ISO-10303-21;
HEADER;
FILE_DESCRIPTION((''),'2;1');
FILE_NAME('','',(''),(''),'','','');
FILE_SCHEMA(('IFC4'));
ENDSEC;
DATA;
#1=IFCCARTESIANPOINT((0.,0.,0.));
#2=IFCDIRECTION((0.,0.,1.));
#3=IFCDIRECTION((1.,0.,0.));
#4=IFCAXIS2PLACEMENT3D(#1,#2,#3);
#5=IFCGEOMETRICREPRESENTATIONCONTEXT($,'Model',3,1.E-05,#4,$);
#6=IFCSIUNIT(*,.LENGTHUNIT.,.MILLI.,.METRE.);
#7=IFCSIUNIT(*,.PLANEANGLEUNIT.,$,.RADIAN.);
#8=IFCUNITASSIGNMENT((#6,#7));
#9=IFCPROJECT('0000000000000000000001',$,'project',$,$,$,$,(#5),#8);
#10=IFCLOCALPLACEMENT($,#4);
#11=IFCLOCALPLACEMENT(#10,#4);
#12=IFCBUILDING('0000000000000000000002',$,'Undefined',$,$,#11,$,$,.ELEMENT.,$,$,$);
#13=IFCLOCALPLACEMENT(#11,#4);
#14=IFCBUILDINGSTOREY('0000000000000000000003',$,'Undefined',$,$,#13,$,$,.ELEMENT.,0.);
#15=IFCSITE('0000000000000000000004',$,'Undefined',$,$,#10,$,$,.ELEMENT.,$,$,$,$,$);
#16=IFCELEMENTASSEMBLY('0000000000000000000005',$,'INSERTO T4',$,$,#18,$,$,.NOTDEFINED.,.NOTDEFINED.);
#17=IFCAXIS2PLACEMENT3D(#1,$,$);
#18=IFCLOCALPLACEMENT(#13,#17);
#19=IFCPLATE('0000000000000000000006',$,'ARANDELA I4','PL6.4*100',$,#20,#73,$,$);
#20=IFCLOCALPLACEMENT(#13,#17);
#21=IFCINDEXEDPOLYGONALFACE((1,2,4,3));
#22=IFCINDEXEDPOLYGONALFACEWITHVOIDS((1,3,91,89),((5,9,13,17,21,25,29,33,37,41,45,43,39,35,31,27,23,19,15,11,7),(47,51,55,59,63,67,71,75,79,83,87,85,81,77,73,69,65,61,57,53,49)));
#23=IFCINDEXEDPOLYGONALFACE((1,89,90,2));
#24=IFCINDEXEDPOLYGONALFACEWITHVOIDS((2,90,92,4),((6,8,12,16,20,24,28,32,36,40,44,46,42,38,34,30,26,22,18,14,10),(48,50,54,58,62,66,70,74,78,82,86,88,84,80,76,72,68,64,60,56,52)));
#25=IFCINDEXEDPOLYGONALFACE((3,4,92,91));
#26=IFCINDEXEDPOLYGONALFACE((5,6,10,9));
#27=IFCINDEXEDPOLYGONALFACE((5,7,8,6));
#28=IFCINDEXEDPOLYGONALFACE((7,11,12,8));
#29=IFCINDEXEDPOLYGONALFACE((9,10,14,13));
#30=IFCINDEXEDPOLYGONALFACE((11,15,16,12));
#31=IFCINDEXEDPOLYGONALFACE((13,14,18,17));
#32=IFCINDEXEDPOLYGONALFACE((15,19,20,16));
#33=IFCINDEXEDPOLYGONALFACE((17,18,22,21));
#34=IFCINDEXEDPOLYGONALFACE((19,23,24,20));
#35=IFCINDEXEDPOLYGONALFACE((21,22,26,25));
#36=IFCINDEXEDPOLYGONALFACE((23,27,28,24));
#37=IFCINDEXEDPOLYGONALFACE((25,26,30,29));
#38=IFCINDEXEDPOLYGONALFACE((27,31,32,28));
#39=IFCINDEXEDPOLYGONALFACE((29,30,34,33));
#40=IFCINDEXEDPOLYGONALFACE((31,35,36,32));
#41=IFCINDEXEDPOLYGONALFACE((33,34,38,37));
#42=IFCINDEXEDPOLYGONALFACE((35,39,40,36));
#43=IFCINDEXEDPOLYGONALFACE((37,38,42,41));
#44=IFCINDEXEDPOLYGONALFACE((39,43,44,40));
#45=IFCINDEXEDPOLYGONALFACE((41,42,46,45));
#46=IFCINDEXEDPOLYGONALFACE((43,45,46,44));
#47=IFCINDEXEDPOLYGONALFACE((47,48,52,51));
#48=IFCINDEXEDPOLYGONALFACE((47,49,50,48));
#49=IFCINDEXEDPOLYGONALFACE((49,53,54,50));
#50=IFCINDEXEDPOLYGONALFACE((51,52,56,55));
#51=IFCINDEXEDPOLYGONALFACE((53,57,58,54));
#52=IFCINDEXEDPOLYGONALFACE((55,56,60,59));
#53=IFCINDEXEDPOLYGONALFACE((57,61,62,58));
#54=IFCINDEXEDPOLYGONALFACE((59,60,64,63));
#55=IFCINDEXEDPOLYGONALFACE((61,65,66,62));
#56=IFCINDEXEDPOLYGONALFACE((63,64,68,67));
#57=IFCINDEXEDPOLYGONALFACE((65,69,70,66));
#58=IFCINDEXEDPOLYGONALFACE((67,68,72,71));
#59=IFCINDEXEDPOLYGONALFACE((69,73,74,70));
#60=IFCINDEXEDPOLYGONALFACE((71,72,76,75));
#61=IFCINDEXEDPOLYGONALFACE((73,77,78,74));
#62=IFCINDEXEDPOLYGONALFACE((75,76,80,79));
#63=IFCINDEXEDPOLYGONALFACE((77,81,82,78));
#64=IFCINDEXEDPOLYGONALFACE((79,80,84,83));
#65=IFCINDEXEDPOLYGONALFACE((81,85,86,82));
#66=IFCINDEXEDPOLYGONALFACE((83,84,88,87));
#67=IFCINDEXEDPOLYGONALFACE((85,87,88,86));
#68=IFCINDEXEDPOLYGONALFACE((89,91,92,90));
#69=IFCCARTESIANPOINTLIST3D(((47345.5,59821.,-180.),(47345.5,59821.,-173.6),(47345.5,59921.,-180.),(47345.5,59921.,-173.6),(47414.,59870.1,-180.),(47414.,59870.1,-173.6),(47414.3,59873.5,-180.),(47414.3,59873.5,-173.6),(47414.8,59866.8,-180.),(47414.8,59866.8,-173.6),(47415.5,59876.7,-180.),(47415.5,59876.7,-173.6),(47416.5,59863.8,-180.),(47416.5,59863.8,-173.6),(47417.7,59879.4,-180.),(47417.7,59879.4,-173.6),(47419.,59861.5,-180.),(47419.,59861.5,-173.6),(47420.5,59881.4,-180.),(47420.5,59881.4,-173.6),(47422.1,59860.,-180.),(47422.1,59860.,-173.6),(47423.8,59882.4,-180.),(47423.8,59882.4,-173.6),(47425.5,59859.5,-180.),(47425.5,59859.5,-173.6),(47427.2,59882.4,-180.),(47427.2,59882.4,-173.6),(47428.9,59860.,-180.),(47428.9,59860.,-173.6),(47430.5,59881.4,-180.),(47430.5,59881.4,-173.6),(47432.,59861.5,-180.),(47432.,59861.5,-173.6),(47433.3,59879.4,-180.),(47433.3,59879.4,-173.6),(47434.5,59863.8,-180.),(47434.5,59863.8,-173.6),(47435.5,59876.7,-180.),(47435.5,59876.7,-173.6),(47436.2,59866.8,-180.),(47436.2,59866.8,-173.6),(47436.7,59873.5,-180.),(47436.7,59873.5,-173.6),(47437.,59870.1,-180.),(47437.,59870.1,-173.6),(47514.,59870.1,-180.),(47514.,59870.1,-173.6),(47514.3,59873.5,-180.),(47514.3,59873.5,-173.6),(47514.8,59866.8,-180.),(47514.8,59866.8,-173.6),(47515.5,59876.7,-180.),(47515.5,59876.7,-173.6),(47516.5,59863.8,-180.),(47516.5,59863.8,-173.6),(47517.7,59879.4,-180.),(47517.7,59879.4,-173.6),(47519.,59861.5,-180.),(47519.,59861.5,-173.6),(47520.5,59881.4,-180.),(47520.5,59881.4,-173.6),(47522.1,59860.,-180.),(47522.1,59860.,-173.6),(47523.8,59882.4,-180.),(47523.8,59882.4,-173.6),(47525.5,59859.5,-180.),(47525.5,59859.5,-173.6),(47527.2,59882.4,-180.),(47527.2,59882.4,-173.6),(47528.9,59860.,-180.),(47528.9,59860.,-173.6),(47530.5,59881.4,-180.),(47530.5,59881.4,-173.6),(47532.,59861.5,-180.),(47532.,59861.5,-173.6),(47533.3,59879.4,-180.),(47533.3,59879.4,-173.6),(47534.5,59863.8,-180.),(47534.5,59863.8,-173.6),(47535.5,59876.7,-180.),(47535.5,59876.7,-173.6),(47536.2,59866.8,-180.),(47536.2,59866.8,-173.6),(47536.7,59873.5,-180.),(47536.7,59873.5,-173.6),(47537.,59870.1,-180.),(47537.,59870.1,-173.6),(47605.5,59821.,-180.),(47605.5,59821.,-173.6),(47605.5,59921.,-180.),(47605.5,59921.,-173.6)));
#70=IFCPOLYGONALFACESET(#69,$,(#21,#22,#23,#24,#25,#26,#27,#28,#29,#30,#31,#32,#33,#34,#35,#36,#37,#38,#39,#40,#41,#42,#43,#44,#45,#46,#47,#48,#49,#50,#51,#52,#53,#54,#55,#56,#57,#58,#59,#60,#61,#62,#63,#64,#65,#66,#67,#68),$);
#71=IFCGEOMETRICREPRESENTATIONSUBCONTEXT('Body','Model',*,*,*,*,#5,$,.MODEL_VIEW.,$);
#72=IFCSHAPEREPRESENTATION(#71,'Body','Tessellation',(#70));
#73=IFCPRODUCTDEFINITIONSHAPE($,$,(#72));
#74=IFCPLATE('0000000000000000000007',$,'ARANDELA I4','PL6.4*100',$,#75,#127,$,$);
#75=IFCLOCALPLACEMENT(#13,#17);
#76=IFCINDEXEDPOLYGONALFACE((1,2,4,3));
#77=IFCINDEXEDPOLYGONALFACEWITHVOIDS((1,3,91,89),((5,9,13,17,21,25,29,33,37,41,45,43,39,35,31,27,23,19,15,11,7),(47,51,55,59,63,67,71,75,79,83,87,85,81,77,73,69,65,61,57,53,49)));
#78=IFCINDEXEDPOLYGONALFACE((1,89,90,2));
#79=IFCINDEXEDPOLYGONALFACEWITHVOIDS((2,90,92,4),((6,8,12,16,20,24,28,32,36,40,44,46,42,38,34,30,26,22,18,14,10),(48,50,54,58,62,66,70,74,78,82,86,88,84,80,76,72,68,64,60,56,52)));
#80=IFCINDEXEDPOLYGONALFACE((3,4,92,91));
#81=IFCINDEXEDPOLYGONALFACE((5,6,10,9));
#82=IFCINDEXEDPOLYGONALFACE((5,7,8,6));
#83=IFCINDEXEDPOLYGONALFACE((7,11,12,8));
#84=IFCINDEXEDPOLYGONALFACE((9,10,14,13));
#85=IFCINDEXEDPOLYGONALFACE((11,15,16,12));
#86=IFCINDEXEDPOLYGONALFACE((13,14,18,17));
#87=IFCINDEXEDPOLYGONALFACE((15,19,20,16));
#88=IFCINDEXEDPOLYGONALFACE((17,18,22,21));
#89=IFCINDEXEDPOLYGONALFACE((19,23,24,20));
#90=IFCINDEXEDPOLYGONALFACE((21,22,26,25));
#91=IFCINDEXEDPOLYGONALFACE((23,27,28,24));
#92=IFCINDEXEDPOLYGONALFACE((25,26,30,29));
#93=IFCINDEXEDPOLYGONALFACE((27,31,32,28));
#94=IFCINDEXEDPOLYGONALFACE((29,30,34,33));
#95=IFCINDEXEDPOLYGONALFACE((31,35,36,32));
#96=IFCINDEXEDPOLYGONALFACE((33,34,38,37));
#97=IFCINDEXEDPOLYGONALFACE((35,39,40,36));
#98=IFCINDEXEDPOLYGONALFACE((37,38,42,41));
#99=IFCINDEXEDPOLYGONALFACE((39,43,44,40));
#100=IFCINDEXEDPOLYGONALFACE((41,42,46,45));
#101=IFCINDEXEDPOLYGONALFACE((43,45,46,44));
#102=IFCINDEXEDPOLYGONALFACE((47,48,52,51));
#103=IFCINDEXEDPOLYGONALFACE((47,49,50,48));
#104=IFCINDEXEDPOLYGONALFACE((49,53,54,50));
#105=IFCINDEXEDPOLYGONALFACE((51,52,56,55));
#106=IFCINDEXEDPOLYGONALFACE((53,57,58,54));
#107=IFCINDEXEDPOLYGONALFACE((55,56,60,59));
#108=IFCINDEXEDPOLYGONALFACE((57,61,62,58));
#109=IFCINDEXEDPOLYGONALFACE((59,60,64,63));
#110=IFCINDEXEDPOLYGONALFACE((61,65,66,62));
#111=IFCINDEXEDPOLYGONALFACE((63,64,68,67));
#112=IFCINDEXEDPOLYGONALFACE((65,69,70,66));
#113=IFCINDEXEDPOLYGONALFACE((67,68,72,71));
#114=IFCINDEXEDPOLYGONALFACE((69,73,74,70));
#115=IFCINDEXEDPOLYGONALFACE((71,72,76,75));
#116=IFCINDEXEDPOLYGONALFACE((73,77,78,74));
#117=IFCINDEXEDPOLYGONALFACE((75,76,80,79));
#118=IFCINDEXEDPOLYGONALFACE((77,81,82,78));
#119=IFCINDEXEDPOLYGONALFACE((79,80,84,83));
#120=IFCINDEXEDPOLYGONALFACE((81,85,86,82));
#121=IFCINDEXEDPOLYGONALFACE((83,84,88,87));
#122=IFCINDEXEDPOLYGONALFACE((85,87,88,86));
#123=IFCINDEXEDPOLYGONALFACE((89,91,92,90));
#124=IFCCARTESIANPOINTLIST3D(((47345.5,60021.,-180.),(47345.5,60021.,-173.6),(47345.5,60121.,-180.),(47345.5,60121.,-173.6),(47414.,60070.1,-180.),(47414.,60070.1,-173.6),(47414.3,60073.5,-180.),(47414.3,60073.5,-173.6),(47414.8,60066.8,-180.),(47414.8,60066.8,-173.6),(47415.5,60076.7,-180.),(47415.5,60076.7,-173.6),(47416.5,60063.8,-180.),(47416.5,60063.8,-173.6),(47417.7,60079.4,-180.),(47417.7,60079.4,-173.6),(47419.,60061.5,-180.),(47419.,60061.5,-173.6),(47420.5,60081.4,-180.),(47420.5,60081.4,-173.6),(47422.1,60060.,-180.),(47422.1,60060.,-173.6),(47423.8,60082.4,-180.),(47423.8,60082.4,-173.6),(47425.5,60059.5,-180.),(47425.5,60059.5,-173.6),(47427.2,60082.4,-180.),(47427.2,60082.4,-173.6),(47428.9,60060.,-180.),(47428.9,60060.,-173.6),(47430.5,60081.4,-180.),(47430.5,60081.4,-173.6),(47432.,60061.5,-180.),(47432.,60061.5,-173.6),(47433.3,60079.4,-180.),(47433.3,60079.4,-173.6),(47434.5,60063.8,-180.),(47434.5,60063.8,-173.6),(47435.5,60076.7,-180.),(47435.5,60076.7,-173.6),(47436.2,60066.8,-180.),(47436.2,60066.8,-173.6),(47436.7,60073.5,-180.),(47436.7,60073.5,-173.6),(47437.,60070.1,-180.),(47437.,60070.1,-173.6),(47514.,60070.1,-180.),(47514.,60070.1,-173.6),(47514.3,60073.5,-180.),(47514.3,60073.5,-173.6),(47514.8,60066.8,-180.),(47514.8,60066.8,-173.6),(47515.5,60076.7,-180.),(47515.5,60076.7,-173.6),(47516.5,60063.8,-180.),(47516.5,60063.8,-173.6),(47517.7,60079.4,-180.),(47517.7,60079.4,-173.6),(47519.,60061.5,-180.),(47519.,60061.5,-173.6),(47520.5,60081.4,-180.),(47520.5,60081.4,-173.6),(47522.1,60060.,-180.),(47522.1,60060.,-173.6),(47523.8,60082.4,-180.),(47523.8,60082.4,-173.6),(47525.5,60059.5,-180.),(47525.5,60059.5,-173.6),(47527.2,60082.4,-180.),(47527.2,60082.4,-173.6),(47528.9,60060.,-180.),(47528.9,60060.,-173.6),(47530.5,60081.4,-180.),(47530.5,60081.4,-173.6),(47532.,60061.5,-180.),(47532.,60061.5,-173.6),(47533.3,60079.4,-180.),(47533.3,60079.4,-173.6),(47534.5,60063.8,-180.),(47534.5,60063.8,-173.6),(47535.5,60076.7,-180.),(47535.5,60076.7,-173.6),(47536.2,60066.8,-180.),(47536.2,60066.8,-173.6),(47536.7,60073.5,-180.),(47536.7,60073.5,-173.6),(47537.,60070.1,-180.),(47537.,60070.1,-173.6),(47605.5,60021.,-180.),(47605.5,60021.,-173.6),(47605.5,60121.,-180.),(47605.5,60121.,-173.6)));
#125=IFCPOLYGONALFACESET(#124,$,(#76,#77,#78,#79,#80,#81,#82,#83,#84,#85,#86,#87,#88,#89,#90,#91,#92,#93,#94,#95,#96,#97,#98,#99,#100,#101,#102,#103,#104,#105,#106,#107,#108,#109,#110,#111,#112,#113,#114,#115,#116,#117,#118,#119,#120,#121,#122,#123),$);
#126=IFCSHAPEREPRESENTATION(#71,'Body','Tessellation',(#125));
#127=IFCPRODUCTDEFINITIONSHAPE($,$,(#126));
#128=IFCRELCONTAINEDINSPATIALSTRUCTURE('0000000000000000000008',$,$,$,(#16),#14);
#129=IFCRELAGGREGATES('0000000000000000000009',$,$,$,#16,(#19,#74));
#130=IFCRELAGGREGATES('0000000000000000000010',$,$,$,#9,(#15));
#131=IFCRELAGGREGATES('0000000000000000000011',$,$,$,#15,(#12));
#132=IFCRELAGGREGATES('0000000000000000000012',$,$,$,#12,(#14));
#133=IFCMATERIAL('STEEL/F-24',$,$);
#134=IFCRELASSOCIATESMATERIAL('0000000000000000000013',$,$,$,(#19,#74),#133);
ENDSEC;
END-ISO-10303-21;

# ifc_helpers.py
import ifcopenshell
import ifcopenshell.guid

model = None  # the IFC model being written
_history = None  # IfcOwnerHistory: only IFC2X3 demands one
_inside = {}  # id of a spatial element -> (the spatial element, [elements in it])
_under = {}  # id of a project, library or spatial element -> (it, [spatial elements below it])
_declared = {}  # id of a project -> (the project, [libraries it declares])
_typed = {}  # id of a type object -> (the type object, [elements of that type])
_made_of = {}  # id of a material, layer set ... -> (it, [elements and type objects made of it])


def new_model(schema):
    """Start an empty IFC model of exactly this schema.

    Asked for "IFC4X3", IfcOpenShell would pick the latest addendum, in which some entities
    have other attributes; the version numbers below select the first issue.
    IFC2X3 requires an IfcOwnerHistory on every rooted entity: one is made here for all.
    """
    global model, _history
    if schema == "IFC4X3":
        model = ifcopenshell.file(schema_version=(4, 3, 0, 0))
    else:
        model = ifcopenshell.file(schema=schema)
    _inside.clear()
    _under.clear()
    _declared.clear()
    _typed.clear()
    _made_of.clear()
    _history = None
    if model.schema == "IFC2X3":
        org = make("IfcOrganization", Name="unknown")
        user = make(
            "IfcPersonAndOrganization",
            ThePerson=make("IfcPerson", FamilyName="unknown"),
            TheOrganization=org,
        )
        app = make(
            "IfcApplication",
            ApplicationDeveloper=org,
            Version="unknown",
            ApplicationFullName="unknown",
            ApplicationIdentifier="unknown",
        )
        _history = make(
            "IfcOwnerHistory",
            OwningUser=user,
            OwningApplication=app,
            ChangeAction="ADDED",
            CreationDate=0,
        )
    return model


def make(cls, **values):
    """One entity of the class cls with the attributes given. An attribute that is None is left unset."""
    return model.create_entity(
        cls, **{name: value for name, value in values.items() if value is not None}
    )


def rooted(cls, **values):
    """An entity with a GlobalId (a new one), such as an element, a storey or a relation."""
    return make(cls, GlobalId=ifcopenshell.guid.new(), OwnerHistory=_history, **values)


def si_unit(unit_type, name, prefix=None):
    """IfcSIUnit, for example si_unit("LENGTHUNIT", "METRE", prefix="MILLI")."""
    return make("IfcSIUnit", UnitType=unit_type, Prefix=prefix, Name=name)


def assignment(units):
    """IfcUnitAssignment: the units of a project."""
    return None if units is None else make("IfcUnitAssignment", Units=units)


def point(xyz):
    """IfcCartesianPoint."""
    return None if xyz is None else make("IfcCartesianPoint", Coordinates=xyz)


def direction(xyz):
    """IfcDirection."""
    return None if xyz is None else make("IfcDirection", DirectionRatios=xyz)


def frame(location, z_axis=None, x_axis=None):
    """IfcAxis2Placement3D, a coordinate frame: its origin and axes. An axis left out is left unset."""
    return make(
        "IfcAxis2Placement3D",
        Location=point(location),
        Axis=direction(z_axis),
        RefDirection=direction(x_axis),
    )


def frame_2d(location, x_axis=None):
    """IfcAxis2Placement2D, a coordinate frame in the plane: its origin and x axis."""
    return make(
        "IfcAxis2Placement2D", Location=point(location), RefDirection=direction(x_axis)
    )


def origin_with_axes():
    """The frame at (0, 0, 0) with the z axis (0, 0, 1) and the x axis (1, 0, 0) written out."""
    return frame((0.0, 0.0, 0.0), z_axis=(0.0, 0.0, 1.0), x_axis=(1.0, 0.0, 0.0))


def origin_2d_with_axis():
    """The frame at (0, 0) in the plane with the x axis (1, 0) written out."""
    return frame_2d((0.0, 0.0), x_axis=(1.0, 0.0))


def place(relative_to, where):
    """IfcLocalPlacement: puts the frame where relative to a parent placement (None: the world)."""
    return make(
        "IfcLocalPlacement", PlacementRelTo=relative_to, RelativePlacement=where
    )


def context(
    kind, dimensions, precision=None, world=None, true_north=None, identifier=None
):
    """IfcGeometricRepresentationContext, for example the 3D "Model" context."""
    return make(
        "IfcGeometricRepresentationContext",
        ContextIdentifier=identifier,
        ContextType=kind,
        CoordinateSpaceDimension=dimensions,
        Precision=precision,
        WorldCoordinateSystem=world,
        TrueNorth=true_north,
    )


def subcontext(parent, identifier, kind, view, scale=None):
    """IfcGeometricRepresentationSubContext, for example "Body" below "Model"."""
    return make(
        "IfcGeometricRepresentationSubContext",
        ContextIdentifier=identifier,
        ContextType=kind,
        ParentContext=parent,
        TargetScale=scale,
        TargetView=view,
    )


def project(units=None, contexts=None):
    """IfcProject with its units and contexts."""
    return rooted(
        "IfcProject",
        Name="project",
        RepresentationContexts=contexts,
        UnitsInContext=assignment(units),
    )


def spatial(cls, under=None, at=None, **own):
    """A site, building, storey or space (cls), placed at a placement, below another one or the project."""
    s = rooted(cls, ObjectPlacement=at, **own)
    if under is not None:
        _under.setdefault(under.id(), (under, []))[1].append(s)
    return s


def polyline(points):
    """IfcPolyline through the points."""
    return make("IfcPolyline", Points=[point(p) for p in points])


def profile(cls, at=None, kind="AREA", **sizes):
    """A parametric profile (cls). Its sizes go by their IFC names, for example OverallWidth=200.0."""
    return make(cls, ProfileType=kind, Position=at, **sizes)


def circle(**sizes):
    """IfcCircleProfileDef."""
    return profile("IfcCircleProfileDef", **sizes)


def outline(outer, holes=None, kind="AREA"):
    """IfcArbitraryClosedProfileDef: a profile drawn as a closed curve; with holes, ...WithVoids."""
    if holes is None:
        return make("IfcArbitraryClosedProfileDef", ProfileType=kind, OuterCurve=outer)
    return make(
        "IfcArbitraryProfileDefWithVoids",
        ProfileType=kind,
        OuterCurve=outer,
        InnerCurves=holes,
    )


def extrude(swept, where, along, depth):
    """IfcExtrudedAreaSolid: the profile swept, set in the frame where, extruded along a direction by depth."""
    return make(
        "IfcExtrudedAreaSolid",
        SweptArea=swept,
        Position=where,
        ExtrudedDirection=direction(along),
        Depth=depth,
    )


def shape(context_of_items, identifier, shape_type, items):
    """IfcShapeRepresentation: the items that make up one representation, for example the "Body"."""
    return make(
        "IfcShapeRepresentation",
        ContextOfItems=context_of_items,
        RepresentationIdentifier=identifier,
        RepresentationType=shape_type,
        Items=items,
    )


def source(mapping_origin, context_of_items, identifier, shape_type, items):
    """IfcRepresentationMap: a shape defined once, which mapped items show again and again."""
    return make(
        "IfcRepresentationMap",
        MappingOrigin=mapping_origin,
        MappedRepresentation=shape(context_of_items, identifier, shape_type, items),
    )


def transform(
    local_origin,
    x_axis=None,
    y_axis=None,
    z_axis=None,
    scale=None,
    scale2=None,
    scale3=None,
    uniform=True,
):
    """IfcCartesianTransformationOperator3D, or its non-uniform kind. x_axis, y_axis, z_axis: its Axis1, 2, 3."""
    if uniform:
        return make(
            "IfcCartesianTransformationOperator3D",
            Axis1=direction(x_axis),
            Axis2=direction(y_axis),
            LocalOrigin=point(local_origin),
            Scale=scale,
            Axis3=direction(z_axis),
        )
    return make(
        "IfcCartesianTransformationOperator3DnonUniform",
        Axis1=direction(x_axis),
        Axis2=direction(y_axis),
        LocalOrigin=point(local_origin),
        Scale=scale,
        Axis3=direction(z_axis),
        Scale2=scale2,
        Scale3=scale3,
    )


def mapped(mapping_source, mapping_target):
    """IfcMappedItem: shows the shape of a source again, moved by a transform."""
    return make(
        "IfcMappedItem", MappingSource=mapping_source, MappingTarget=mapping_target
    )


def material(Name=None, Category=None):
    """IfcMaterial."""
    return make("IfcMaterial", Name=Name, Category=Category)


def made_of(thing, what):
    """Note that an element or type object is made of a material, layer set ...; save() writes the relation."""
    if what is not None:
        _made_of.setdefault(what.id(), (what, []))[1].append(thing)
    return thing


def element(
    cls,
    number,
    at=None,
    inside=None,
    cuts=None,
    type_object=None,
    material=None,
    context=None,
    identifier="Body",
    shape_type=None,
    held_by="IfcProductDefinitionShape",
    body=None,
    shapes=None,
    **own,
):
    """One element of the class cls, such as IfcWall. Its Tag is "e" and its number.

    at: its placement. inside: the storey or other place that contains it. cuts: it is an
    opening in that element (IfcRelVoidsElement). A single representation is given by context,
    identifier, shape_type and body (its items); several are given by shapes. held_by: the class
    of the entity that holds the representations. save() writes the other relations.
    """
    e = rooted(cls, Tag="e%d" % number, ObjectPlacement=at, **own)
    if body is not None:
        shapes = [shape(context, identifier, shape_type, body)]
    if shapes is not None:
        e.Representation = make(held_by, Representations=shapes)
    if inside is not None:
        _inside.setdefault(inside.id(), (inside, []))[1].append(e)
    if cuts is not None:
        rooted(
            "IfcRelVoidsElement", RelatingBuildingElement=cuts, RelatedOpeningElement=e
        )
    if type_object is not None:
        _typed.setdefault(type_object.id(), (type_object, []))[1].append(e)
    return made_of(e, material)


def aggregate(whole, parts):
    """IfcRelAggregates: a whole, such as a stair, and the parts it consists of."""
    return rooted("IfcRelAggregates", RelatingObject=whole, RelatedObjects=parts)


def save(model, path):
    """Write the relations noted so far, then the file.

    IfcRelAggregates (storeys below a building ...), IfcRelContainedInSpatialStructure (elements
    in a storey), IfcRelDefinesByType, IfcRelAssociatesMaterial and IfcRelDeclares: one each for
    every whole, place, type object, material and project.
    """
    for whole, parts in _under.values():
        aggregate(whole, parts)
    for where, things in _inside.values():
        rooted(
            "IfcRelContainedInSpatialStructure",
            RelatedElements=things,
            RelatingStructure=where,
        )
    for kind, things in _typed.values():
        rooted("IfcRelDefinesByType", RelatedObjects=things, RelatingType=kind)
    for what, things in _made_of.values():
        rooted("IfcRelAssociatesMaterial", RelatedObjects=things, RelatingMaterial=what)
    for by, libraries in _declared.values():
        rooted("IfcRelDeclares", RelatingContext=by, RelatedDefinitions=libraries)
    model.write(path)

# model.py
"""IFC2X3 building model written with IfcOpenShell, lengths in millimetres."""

from ifc_helpers import new_model, si_unit, frame, origin_with_axes, origin_2d_with_axis, place, context, subcontext, project, spatial, polyline, circle, outline, extrude, source, transform, mapped, material, element, aggregate, save


model = new_model("IFC2X3")

# Units and contexts
model_context = context("Model", 3, precision=1e-05, world=origin_with_axes())
body_context = subcontext(model_context, "Body", "Model", "MODEL_VIEW")
ifc_project = project(units=[si_unit("LENGTHUNIT", "METRE", prefix="MILLI"), si_unit("PLANEANGLEUNIT", "RADIAN")], contexts=[model_context])

# Site, building, storey
site_placement = place(None, origin_with_axes())
site = spatial("IfcSite", under=ifc_project, at=site_placement, Name="Undefined", CompositionType="ELEMENT")
building_placement = place(site_placement, origin_with_axes())
building = spatial("IfcBuilding", under=site, at=building_placement, Name="Undefined", CompositionType="ELEMENT")
storey_placement = place(building_placement, origin_with_axes())
storey = spatial("IfcBuildingStorey", under=building, at=storey_placement, Name="Undefined", CompositionType="ELEMENT", Elevation=0.0)

# Element assembly
assembly_1_placement = place(storey_placement, origin_with_axes())
assembly_1 = element("IfcElementAssembly", 1, at=assembly_1_placement, inside=storey, Name="INSERTO T4", AssemblyPlace="NOTDEFINED", PredefinedType="NOTDEFINED")

# Plates, openings
ifc_material_1 = material(Name="STEEL/F-24")
plate_1_placement = place(assembly_1_placement, frame((47345.5, 59821.0, -176.8), z_axis=(0.0, 0.0, -1.0), x_axis=(0.0, 1.0, 0.0)))
plate_1 = element("IfcPlate", 2, at=plate_1_placement, material=ifc_material_1, Name="ARANDELA I4", Description="PL6.4*100", context=body_context, shape_type="SweptSolid", body=[
    extrude(outline(polyline([(0.0, 0.0), (100.0, 0.0), (100.0, 260.0), (0.0, 260.0), (0.0, 0.0)])), frame((0.0, 0.0, -3.2), z_axis=(0.0, 0.0, 1.0), x_axis=(1.0, 0.0, 0.0)), (0.0, 0.0, 1.0), 6.4),
])
shared_shape_1 = source(origin_with_axes(), body_context, "Body", "SweptSolid", [
    extrude(circle(Radius=11.5, at=origin_2d_with_axis()), frame((0.0, -0.1, 0.0), z_axis=(0.0, 1.0, 0.0), x_axis=(1.0, 0.0, 0.0)), (0.0, 0.0, 1.0), 6.6),
])
opening_1_placement = place(assembly_1_placement, frame((47475.5, 59871.0, -173.6), z_axis=(1.0, 0.0, 0.0), x_axis=(0.0, -1.0, 0.0)))
element("IfcOpeningElement", 3, at=opening_1_placement, cuts=plate_1, ObjectType="Opening", context=body_context, shape_type="MappedRepresentation", body=[
    mapped(shared_shape_1, transform((0.0, 0.0, 50.0))),
    mapped(shared_shape_1, transform((0.0, 0.0, -50.0))),
])
plate_2_placement = place(assembly_1_placement, frame((47345.5, 60021.0, -176.8), z_axis=(0.0, 0.0, -1.0), x_axis=(0.0, 1.0, 0.0)))
plate_2 = element("IfcPlate", 4, at=plate_2_placement, material=ifc_material_1, Name="ARANDELA I4", Description="PL6.4*100", context=body_context, shape_type="SweptSolid", body=[
    extrude(outline(polyline([(0.0, 0.0), (100.0, 0.0), (100.0, 260.0), (0.0, 260.0), (0.0, 0.0)])), frame((0.0, 0.0, -3.2), z_axis=(0.0, 0.0, 1.0), x_axis=(1.0, 0.0, 0.0)), (0.0, 0.0, 1.0), 6.4),
])
opening_2_placement = place(assembly_1_placement, frame((47475.5, 60071.0, -173.6), z_axis=(1.0, 0.0, 0.0), x_axis=(0.0, -1.0, 0.0)))
element("IfcOpeningElement", 5, at=opening_2_placement, cuts=plate_2, ObjectType="Opening", context=body_context, shape_type="MappedRepresentation", body=[
    mapped(shared_shape_1, transform((0.0, 0.0, 50.0))),
    mapped(shared_shape_1, transform((0.0, 0.0, -50.0))),
])
aggregate(assembly_1, [plate_1, plate_2])

save(model, "model.ifc")
